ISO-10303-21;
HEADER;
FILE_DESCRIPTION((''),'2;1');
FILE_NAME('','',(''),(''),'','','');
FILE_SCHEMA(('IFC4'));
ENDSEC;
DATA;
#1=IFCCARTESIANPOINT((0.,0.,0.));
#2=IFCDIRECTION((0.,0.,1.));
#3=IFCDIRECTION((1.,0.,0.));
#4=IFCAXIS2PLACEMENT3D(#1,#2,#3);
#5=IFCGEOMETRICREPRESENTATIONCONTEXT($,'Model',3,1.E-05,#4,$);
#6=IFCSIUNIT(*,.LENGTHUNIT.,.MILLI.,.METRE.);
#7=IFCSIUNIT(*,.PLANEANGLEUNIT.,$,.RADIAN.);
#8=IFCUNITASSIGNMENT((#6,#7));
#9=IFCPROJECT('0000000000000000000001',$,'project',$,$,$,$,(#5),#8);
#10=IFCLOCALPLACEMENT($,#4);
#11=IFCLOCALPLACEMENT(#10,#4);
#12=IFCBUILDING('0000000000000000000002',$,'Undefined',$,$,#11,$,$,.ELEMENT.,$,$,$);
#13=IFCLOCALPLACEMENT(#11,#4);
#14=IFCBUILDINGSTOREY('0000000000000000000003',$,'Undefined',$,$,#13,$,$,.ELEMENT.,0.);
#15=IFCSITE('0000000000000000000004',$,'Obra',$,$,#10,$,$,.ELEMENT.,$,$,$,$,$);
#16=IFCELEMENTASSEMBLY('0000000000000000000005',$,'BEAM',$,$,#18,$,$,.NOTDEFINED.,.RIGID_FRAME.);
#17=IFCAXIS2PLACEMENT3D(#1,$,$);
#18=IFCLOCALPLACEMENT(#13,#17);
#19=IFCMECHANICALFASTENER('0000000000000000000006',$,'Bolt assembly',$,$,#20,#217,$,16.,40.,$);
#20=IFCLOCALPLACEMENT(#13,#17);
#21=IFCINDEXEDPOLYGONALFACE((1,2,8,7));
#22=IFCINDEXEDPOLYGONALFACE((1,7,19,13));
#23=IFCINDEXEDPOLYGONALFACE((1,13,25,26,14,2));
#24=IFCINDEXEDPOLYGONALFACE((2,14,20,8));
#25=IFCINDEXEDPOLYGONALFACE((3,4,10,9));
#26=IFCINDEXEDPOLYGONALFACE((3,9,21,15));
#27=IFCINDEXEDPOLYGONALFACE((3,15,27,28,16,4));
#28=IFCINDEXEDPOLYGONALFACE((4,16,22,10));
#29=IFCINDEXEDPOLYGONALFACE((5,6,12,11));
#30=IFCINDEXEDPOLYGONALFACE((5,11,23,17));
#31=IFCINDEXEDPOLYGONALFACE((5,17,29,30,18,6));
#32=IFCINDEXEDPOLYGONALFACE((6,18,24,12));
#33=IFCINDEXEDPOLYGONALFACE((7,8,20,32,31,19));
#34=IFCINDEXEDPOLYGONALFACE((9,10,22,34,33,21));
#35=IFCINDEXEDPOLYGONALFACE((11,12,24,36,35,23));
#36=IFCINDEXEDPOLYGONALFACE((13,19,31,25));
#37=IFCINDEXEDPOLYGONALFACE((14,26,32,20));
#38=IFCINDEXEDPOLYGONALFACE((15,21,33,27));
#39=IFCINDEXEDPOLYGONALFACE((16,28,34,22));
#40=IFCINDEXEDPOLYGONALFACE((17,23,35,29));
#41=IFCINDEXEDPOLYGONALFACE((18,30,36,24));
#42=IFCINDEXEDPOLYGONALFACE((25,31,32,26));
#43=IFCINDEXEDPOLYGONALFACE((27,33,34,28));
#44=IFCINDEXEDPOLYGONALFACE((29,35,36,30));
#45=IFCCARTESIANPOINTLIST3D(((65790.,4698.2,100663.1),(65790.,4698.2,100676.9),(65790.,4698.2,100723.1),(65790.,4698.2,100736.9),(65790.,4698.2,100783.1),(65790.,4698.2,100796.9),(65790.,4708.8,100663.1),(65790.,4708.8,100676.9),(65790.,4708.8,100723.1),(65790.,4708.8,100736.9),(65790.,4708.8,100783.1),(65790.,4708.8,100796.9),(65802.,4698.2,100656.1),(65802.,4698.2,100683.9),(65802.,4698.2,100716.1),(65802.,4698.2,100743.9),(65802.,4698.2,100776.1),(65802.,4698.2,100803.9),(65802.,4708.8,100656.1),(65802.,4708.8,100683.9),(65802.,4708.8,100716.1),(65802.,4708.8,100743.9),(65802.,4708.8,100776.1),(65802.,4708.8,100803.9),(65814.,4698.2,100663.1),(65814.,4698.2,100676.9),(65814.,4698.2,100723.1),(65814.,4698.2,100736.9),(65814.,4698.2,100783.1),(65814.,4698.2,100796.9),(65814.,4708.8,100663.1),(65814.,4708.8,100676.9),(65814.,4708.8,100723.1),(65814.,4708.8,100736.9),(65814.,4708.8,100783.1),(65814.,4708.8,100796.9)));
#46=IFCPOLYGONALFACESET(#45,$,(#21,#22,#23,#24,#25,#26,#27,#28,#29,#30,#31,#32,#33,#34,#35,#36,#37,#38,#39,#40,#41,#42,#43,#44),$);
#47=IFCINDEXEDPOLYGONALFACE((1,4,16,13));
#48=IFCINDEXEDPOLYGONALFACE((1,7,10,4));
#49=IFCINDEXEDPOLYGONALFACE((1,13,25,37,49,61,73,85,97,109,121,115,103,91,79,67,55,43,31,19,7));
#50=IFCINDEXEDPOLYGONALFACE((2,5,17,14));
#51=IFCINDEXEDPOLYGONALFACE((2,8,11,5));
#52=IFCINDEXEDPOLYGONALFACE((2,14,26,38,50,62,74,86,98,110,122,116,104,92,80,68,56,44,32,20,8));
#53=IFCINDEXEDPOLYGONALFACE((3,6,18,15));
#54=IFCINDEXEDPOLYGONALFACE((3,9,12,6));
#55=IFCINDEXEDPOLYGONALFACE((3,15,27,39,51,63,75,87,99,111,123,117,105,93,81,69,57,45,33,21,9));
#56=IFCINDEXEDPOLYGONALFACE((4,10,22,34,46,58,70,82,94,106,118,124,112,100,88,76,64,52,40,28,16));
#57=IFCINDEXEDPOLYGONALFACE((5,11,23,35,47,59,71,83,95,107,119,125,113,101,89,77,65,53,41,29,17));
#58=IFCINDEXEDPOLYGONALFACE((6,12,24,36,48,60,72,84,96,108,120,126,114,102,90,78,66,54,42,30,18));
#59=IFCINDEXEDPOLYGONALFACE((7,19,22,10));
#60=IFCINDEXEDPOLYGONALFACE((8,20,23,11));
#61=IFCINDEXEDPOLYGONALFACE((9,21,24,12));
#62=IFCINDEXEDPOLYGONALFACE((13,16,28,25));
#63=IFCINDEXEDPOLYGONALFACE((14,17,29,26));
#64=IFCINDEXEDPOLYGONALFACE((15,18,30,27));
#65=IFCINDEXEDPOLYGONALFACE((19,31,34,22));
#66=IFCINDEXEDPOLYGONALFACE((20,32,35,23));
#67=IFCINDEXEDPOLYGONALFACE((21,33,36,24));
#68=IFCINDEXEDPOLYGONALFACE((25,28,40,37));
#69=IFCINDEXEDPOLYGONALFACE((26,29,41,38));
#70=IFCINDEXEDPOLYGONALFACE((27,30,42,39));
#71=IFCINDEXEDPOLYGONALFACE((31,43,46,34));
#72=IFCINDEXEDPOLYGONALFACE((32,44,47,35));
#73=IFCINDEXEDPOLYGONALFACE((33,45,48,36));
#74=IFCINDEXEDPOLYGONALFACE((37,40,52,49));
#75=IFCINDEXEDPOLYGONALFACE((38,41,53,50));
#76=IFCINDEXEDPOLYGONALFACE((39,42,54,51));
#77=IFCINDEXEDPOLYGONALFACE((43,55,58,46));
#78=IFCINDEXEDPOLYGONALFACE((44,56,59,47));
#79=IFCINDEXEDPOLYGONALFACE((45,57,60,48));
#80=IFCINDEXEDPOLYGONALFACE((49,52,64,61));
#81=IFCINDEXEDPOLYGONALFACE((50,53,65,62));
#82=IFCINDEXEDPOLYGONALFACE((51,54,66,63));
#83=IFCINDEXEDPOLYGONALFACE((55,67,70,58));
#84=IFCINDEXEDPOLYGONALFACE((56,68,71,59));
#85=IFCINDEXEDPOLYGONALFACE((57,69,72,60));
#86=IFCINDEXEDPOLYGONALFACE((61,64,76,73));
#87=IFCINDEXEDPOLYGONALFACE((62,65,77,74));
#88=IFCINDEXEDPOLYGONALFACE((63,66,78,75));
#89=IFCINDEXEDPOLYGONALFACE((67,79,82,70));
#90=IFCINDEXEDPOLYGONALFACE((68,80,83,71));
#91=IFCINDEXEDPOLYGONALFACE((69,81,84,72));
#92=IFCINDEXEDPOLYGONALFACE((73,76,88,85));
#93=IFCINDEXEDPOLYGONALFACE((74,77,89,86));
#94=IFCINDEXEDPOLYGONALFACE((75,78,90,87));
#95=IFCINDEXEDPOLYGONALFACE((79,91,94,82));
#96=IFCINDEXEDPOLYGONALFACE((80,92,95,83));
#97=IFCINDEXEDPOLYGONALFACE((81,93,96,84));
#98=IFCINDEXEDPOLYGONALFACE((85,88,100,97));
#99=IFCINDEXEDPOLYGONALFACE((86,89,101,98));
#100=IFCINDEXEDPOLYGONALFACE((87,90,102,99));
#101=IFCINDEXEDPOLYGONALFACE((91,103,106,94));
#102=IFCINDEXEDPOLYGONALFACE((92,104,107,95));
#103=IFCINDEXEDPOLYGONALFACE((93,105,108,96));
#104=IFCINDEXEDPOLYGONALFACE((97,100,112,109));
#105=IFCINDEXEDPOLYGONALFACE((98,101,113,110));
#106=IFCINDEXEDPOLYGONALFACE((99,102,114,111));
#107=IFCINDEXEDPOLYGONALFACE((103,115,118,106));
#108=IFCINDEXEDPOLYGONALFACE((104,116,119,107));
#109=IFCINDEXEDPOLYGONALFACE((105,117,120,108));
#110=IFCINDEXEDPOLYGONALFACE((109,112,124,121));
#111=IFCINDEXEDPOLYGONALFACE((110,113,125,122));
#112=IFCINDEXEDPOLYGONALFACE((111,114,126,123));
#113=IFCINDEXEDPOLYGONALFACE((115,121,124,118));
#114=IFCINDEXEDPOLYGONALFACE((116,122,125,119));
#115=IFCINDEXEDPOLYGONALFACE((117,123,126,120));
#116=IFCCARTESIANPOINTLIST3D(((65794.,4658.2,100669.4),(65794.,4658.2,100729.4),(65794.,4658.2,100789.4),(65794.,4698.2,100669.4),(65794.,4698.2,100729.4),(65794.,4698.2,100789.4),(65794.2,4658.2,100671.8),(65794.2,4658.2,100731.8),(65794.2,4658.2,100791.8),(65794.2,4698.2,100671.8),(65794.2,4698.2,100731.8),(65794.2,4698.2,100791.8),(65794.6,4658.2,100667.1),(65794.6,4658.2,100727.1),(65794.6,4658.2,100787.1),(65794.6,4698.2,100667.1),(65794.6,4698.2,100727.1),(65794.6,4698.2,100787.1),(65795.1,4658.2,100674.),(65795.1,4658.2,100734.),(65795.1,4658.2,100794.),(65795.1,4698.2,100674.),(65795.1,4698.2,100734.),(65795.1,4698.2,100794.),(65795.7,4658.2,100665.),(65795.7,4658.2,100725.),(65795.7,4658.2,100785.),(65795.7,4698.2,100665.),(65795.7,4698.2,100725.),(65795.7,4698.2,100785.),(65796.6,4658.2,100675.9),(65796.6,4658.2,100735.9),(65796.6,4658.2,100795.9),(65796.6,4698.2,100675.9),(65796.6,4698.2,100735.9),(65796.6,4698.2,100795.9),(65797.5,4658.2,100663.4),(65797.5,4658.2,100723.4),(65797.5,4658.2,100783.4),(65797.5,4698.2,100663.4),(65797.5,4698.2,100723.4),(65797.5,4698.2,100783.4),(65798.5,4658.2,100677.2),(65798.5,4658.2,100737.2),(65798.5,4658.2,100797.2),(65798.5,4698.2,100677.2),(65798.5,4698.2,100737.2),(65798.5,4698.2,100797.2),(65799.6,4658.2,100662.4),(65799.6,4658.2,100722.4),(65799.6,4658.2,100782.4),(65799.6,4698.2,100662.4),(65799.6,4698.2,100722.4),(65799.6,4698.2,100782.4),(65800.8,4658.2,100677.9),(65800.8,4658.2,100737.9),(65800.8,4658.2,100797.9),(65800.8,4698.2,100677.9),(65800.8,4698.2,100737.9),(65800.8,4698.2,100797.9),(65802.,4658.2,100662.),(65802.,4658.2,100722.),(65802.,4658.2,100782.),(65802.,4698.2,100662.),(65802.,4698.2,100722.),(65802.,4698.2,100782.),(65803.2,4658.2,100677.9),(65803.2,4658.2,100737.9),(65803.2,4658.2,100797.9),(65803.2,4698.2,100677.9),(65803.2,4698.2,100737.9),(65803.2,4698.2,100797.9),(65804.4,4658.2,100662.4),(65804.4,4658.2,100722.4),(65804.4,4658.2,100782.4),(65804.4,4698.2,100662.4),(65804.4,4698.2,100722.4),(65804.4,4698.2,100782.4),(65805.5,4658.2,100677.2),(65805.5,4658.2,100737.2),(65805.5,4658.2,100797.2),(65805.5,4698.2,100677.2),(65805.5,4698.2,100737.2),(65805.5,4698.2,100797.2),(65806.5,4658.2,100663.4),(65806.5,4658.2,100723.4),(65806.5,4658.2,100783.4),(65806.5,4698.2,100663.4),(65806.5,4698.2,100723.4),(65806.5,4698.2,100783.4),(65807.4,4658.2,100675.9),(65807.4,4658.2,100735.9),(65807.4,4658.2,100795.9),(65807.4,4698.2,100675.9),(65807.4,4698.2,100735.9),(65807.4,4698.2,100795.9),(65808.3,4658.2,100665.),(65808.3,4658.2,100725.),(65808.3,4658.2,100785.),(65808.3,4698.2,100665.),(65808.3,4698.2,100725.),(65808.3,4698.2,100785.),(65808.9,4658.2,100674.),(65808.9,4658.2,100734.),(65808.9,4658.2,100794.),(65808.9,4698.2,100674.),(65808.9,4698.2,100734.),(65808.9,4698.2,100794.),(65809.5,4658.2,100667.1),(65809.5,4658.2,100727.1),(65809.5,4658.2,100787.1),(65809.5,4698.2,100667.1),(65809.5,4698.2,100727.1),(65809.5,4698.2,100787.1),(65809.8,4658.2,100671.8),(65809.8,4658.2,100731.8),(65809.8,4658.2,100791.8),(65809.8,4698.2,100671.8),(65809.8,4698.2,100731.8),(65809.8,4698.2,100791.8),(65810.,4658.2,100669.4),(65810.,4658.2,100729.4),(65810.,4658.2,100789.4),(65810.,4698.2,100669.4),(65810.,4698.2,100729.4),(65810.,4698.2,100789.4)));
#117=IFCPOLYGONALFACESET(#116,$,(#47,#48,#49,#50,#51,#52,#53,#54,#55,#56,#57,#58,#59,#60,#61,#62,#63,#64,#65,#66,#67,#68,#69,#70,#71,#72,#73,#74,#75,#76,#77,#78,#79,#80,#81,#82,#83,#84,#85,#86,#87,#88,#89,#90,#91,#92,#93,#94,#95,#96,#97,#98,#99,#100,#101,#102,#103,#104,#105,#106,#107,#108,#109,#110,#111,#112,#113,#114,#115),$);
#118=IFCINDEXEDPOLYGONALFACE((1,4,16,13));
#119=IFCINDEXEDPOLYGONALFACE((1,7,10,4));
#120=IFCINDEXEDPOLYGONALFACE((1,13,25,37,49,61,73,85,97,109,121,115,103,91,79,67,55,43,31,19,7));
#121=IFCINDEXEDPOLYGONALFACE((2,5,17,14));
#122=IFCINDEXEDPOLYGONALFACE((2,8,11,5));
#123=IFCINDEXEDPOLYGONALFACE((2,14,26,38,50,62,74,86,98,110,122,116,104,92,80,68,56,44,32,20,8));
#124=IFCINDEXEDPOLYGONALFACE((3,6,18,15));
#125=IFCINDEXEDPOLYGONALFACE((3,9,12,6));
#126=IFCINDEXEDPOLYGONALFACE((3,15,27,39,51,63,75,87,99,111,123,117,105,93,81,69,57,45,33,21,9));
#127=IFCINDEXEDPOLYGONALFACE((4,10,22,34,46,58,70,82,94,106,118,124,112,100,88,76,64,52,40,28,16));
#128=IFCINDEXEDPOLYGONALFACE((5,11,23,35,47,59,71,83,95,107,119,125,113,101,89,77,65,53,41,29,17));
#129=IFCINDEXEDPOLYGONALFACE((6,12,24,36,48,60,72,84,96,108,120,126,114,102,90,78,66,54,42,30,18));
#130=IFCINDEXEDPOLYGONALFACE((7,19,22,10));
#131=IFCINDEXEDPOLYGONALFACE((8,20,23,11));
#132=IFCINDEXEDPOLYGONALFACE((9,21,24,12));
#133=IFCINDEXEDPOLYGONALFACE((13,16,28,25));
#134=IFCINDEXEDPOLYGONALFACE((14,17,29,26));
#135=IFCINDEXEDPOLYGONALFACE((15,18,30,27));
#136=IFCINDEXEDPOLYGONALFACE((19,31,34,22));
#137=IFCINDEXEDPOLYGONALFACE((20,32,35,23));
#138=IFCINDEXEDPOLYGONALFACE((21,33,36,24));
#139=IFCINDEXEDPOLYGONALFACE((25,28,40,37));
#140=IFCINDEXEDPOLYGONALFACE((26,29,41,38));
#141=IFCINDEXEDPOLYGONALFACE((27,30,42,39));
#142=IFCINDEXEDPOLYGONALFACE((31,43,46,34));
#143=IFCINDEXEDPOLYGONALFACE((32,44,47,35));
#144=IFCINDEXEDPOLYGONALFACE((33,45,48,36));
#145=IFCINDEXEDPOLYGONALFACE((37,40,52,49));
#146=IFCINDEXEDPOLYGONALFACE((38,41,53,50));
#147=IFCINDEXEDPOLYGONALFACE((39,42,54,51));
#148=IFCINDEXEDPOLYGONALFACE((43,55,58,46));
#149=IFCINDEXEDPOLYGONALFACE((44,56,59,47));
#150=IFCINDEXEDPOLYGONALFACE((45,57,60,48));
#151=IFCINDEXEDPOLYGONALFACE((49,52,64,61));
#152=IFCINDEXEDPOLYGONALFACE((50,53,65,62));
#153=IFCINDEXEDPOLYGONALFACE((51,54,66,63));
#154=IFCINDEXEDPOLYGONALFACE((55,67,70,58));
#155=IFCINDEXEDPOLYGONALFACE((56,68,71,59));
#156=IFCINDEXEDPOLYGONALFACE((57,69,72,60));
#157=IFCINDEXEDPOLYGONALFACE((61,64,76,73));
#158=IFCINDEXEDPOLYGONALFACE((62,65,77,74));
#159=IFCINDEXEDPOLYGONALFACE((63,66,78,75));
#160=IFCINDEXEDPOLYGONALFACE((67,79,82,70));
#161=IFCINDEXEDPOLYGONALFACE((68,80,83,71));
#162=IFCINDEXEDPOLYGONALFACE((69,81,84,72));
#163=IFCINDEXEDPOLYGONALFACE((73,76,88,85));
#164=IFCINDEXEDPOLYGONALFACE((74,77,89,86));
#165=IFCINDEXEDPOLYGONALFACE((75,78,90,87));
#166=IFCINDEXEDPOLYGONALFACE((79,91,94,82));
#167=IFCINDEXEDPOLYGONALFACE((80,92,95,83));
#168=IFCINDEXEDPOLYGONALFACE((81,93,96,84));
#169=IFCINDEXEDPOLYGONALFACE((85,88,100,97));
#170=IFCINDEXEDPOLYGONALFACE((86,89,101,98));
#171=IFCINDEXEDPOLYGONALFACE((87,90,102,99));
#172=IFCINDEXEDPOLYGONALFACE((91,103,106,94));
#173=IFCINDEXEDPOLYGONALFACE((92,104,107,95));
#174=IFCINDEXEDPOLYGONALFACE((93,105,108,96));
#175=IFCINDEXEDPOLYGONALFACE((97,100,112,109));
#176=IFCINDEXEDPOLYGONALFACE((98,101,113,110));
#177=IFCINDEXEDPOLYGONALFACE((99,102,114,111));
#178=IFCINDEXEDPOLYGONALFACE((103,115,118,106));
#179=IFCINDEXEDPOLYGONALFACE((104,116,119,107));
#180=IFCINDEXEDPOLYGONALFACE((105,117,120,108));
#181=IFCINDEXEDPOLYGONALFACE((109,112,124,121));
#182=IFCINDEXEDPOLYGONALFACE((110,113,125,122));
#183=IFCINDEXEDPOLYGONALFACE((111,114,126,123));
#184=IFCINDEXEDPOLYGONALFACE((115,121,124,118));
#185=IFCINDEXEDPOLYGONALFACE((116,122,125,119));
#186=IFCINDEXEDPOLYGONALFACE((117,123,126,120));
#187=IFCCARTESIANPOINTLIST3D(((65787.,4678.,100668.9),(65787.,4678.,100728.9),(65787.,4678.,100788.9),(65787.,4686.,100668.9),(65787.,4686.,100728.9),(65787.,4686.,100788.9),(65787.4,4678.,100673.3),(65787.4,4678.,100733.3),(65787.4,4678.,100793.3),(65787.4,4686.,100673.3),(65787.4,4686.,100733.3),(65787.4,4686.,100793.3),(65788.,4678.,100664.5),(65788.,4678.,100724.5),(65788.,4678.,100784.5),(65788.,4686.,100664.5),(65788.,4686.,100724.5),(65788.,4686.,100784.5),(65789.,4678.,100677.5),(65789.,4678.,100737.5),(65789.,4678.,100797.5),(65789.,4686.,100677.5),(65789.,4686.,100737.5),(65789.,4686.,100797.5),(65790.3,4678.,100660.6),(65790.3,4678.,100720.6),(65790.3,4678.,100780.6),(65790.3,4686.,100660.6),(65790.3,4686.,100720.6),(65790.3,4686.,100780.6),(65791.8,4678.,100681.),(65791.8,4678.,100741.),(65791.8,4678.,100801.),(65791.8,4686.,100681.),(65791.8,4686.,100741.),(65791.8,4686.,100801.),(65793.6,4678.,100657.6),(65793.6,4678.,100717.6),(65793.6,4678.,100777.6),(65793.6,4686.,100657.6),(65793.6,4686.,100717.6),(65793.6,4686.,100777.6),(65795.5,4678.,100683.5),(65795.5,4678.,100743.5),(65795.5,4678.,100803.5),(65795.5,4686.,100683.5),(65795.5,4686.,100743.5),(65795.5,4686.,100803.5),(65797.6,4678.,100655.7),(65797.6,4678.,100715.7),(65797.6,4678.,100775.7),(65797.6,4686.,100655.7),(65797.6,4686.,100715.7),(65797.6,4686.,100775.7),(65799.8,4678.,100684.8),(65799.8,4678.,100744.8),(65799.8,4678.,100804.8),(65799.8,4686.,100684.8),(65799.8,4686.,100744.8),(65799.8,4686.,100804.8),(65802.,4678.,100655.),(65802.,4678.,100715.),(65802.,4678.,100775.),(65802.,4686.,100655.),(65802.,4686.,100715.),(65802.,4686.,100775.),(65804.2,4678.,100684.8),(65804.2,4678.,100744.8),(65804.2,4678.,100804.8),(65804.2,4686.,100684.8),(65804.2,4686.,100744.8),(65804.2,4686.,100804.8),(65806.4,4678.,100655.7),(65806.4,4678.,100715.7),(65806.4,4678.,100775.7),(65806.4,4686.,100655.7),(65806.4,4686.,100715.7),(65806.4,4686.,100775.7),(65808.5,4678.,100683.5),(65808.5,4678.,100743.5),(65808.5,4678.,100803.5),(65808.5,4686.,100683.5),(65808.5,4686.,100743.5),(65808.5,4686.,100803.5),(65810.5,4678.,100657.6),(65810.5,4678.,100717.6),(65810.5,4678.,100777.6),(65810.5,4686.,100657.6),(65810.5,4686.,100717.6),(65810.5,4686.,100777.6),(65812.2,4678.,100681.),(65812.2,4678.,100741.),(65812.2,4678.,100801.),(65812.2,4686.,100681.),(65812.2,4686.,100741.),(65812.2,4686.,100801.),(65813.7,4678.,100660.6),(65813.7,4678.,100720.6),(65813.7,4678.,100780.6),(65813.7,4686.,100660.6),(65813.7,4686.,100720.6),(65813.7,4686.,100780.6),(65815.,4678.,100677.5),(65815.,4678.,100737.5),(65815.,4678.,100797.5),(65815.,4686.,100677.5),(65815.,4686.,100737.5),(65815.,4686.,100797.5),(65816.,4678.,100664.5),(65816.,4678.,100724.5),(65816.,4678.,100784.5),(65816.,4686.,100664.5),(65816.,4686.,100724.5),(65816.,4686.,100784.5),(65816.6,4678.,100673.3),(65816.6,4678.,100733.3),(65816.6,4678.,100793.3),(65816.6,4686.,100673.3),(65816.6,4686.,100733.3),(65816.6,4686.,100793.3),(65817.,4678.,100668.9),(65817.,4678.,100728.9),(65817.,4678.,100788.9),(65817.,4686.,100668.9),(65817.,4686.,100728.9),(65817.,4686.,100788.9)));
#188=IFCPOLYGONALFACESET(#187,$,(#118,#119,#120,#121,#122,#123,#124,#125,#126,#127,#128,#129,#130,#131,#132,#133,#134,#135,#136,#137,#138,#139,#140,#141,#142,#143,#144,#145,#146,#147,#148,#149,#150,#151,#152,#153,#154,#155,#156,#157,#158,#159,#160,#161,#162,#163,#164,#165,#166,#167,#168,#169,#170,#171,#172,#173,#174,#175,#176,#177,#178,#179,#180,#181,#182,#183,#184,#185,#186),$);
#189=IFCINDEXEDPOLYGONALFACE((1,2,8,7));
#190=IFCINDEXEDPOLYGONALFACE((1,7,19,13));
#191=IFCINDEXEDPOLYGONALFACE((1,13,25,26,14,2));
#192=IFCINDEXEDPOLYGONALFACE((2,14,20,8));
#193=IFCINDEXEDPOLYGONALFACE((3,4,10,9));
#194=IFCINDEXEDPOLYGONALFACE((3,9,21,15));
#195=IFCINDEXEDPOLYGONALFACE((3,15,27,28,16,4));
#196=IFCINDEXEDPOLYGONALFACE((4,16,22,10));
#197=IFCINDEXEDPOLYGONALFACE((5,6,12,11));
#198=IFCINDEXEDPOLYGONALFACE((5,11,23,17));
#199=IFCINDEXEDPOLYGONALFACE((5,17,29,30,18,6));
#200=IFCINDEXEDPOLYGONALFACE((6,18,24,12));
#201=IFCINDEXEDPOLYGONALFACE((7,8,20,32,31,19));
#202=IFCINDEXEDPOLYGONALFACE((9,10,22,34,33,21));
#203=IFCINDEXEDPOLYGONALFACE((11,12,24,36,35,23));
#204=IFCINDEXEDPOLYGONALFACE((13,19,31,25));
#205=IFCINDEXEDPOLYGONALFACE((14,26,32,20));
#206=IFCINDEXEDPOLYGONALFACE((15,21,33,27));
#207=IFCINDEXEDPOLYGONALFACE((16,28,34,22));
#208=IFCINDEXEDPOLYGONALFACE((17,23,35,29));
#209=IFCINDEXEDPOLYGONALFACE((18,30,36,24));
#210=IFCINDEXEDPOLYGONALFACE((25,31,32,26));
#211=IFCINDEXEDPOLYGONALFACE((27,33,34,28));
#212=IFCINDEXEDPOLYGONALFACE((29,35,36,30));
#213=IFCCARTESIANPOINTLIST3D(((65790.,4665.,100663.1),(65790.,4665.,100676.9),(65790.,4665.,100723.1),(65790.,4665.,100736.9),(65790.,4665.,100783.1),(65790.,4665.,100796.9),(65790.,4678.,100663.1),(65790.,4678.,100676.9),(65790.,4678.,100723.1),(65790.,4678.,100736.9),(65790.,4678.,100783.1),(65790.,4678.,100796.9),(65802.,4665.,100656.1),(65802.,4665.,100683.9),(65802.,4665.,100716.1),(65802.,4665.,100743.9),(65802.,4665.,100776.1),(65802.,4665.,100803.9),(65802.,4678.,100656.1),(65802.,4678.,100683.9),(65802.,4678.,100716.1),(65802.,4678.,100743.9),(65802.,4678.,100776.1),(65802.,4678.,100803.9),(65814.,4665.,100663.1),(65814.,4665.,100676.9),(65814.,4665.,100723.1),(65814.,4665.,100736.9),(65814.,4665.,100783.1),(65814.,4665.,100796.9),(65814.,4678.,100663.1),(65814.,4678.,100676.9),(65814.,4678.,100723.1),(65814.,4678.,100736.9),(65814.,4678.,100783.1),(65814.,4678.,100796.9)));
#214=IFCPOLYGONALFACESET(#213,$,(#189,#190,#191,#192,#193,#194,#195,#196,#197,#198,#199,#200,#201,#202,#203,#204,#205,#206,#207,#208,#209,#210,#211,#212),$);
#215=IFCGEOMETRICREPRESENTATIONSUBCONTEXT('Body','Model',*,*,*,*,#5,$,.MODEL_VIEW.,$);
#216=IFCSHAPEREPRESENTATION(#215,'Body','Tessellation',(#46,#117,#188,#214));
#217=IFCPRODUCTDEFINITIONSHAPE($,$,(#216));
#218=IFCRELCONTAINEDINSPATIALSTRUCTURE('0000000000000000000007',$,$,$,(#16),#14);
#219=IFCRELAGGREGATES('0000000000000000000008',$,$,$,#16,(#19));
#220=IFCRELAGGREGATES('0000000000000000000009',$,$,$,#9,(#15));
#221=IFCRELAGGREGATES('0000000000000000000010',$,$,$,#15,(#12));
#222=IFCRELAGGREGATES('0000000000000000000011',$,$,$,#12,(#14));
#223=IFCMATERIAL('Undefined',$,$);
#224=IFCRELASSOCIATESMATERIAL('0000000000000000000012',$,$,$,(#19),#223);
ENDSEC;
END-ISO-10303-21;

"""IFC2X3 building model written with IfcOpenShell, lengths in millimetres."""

from ifc_helpers import new_model, si_unit, frame, origin_with_axes, origin_2d_with_axis, place, context, subcontext, project, spatial, polyline, circle, outline, extrude, source, transform, mapped, material, element, aggregate, save


model = new_model("IFC2X3")

# Units and contexts
model_context = context("Model", 3, precision=1e-05, world=origin_with_axes())
body_context = subcontext(model_context, "Body", "Model", "MODEL_VIEW")
ifc_project = project(units=[si_unit("LENGTHUNIT", "METRE", prefix="MILLI"), si_unit("PLANEANGLEUNIT", "RADIAN")], contexts=[model_context])

# Site, building, storey
site_placement = place(None, origin_with_axes())
site = spatial("IfcSite", under=ifc_project, at=site_placement, Name="Obra", CompositionType="ELEMENT")
building_placement = place(site_placement, origin_with_axes())
building = spatial("IfcBuilding", under=site, at=building_placement, Name="Undefined", CompositionType="ELEMENT")
storey_placement = place(building_placement, origin_with_axes())
storey = spatial("IfcBuildingStorey", under=building, at=storey_placement, Name="Undefined", CompositionType="ELEMENT", Elevation=0.0)

# Shared definitions
ifc_material_1 = material(Name="Undefined")

# Shared definitions
shared_shape_1 = source(origin_with_axes(), body_context, "Body", "SweptSolid", [
    extrude(outline(polyline([(13.9, 0.0), (6.9, 12.0), (-6.9, 12.0), (-13.9, 0.0), (-6.9, -12.0), (6.9, -12.0), (13.9, 0.0)])), frame((0.0, -19.7, 0.0), z_axis=(0.0, 1.0, 0.0), x_axis=(1.0, 0.0, 0.0)), (0.0, 0.0, 1.0), 10.6),
    extrude(circle(Radius=8.0, at=origin_2d_with_axis()), frame((0.0, -9.1, 0.0), z_axis=(0.0, 1.0, 0.0), x_axis=(1.0, 0.0, 0.0)), (0.0, 0.0, 1.0), 40.0),
    extrude(circle(Radius=15.0, at=origin_2d_with_axis()), frame((0.0, 3.1, 0.0), z_axis=(0.0, 1.0, 0.0), x_axis=(1.0, 0.0, 0.0)), (0.0, 0.0, 1.0), 8.0),
    extrude(outline(polyline([(13.9, 0.0), (6.9, 12.0), (-6.9, 12.0), (-13.9, 0.0), (-6.9, -12.0), (6.9, -12.0), (13.9, 0.0)])), frame((0.0, 11.1, 0.0), z_axis=(0.0, 1.0, 0.0), x_axis=(1.0, 0.0, 0.0)), (0.0, 0.0, 1.0), 13.0),
])

# Element assembly, mechanical fastener
assembly_1_placement = place(storey_placement, origin_with_axes())
assembly_1 = element("IfcElementAssembly", 1, at=assembly_1_placement, inside=storey, Name="BEAM", AssemblyPlace="NOTDEFINED", PredefinedType="RIGID_FRAME")
mechanical_fastener_1_placement = place(assembly_1_placement, frame((65852.0, 4689.1, 100850.0), z_axis=(-1.0, 0.0, 0.0), x_axis=(0.0, 0.0, -1.0)))
mechanical_fastener_1 = element("IfcMechanicalFastener", 2, at=mechanical_fastener_1_placement, material=ifc_material_1, Name="Bolt assembly", NominalDiameter=16.0, NominalLength=40.0, context=body_context, shape_type="MappedRepresentation", body=[
    mapped(shared_shape_1, transform((60.0, 0.0, 50.0))),
    mapped(shared_shape_1, transform((120.0, 0.0, 50.0))),
    mapped(shared_shape_1, transform((180.0, 0.0, 50.0))),
])
aggregate(assembly_1, [mechanical_fastener_1])

save(model, "model.ifc")
